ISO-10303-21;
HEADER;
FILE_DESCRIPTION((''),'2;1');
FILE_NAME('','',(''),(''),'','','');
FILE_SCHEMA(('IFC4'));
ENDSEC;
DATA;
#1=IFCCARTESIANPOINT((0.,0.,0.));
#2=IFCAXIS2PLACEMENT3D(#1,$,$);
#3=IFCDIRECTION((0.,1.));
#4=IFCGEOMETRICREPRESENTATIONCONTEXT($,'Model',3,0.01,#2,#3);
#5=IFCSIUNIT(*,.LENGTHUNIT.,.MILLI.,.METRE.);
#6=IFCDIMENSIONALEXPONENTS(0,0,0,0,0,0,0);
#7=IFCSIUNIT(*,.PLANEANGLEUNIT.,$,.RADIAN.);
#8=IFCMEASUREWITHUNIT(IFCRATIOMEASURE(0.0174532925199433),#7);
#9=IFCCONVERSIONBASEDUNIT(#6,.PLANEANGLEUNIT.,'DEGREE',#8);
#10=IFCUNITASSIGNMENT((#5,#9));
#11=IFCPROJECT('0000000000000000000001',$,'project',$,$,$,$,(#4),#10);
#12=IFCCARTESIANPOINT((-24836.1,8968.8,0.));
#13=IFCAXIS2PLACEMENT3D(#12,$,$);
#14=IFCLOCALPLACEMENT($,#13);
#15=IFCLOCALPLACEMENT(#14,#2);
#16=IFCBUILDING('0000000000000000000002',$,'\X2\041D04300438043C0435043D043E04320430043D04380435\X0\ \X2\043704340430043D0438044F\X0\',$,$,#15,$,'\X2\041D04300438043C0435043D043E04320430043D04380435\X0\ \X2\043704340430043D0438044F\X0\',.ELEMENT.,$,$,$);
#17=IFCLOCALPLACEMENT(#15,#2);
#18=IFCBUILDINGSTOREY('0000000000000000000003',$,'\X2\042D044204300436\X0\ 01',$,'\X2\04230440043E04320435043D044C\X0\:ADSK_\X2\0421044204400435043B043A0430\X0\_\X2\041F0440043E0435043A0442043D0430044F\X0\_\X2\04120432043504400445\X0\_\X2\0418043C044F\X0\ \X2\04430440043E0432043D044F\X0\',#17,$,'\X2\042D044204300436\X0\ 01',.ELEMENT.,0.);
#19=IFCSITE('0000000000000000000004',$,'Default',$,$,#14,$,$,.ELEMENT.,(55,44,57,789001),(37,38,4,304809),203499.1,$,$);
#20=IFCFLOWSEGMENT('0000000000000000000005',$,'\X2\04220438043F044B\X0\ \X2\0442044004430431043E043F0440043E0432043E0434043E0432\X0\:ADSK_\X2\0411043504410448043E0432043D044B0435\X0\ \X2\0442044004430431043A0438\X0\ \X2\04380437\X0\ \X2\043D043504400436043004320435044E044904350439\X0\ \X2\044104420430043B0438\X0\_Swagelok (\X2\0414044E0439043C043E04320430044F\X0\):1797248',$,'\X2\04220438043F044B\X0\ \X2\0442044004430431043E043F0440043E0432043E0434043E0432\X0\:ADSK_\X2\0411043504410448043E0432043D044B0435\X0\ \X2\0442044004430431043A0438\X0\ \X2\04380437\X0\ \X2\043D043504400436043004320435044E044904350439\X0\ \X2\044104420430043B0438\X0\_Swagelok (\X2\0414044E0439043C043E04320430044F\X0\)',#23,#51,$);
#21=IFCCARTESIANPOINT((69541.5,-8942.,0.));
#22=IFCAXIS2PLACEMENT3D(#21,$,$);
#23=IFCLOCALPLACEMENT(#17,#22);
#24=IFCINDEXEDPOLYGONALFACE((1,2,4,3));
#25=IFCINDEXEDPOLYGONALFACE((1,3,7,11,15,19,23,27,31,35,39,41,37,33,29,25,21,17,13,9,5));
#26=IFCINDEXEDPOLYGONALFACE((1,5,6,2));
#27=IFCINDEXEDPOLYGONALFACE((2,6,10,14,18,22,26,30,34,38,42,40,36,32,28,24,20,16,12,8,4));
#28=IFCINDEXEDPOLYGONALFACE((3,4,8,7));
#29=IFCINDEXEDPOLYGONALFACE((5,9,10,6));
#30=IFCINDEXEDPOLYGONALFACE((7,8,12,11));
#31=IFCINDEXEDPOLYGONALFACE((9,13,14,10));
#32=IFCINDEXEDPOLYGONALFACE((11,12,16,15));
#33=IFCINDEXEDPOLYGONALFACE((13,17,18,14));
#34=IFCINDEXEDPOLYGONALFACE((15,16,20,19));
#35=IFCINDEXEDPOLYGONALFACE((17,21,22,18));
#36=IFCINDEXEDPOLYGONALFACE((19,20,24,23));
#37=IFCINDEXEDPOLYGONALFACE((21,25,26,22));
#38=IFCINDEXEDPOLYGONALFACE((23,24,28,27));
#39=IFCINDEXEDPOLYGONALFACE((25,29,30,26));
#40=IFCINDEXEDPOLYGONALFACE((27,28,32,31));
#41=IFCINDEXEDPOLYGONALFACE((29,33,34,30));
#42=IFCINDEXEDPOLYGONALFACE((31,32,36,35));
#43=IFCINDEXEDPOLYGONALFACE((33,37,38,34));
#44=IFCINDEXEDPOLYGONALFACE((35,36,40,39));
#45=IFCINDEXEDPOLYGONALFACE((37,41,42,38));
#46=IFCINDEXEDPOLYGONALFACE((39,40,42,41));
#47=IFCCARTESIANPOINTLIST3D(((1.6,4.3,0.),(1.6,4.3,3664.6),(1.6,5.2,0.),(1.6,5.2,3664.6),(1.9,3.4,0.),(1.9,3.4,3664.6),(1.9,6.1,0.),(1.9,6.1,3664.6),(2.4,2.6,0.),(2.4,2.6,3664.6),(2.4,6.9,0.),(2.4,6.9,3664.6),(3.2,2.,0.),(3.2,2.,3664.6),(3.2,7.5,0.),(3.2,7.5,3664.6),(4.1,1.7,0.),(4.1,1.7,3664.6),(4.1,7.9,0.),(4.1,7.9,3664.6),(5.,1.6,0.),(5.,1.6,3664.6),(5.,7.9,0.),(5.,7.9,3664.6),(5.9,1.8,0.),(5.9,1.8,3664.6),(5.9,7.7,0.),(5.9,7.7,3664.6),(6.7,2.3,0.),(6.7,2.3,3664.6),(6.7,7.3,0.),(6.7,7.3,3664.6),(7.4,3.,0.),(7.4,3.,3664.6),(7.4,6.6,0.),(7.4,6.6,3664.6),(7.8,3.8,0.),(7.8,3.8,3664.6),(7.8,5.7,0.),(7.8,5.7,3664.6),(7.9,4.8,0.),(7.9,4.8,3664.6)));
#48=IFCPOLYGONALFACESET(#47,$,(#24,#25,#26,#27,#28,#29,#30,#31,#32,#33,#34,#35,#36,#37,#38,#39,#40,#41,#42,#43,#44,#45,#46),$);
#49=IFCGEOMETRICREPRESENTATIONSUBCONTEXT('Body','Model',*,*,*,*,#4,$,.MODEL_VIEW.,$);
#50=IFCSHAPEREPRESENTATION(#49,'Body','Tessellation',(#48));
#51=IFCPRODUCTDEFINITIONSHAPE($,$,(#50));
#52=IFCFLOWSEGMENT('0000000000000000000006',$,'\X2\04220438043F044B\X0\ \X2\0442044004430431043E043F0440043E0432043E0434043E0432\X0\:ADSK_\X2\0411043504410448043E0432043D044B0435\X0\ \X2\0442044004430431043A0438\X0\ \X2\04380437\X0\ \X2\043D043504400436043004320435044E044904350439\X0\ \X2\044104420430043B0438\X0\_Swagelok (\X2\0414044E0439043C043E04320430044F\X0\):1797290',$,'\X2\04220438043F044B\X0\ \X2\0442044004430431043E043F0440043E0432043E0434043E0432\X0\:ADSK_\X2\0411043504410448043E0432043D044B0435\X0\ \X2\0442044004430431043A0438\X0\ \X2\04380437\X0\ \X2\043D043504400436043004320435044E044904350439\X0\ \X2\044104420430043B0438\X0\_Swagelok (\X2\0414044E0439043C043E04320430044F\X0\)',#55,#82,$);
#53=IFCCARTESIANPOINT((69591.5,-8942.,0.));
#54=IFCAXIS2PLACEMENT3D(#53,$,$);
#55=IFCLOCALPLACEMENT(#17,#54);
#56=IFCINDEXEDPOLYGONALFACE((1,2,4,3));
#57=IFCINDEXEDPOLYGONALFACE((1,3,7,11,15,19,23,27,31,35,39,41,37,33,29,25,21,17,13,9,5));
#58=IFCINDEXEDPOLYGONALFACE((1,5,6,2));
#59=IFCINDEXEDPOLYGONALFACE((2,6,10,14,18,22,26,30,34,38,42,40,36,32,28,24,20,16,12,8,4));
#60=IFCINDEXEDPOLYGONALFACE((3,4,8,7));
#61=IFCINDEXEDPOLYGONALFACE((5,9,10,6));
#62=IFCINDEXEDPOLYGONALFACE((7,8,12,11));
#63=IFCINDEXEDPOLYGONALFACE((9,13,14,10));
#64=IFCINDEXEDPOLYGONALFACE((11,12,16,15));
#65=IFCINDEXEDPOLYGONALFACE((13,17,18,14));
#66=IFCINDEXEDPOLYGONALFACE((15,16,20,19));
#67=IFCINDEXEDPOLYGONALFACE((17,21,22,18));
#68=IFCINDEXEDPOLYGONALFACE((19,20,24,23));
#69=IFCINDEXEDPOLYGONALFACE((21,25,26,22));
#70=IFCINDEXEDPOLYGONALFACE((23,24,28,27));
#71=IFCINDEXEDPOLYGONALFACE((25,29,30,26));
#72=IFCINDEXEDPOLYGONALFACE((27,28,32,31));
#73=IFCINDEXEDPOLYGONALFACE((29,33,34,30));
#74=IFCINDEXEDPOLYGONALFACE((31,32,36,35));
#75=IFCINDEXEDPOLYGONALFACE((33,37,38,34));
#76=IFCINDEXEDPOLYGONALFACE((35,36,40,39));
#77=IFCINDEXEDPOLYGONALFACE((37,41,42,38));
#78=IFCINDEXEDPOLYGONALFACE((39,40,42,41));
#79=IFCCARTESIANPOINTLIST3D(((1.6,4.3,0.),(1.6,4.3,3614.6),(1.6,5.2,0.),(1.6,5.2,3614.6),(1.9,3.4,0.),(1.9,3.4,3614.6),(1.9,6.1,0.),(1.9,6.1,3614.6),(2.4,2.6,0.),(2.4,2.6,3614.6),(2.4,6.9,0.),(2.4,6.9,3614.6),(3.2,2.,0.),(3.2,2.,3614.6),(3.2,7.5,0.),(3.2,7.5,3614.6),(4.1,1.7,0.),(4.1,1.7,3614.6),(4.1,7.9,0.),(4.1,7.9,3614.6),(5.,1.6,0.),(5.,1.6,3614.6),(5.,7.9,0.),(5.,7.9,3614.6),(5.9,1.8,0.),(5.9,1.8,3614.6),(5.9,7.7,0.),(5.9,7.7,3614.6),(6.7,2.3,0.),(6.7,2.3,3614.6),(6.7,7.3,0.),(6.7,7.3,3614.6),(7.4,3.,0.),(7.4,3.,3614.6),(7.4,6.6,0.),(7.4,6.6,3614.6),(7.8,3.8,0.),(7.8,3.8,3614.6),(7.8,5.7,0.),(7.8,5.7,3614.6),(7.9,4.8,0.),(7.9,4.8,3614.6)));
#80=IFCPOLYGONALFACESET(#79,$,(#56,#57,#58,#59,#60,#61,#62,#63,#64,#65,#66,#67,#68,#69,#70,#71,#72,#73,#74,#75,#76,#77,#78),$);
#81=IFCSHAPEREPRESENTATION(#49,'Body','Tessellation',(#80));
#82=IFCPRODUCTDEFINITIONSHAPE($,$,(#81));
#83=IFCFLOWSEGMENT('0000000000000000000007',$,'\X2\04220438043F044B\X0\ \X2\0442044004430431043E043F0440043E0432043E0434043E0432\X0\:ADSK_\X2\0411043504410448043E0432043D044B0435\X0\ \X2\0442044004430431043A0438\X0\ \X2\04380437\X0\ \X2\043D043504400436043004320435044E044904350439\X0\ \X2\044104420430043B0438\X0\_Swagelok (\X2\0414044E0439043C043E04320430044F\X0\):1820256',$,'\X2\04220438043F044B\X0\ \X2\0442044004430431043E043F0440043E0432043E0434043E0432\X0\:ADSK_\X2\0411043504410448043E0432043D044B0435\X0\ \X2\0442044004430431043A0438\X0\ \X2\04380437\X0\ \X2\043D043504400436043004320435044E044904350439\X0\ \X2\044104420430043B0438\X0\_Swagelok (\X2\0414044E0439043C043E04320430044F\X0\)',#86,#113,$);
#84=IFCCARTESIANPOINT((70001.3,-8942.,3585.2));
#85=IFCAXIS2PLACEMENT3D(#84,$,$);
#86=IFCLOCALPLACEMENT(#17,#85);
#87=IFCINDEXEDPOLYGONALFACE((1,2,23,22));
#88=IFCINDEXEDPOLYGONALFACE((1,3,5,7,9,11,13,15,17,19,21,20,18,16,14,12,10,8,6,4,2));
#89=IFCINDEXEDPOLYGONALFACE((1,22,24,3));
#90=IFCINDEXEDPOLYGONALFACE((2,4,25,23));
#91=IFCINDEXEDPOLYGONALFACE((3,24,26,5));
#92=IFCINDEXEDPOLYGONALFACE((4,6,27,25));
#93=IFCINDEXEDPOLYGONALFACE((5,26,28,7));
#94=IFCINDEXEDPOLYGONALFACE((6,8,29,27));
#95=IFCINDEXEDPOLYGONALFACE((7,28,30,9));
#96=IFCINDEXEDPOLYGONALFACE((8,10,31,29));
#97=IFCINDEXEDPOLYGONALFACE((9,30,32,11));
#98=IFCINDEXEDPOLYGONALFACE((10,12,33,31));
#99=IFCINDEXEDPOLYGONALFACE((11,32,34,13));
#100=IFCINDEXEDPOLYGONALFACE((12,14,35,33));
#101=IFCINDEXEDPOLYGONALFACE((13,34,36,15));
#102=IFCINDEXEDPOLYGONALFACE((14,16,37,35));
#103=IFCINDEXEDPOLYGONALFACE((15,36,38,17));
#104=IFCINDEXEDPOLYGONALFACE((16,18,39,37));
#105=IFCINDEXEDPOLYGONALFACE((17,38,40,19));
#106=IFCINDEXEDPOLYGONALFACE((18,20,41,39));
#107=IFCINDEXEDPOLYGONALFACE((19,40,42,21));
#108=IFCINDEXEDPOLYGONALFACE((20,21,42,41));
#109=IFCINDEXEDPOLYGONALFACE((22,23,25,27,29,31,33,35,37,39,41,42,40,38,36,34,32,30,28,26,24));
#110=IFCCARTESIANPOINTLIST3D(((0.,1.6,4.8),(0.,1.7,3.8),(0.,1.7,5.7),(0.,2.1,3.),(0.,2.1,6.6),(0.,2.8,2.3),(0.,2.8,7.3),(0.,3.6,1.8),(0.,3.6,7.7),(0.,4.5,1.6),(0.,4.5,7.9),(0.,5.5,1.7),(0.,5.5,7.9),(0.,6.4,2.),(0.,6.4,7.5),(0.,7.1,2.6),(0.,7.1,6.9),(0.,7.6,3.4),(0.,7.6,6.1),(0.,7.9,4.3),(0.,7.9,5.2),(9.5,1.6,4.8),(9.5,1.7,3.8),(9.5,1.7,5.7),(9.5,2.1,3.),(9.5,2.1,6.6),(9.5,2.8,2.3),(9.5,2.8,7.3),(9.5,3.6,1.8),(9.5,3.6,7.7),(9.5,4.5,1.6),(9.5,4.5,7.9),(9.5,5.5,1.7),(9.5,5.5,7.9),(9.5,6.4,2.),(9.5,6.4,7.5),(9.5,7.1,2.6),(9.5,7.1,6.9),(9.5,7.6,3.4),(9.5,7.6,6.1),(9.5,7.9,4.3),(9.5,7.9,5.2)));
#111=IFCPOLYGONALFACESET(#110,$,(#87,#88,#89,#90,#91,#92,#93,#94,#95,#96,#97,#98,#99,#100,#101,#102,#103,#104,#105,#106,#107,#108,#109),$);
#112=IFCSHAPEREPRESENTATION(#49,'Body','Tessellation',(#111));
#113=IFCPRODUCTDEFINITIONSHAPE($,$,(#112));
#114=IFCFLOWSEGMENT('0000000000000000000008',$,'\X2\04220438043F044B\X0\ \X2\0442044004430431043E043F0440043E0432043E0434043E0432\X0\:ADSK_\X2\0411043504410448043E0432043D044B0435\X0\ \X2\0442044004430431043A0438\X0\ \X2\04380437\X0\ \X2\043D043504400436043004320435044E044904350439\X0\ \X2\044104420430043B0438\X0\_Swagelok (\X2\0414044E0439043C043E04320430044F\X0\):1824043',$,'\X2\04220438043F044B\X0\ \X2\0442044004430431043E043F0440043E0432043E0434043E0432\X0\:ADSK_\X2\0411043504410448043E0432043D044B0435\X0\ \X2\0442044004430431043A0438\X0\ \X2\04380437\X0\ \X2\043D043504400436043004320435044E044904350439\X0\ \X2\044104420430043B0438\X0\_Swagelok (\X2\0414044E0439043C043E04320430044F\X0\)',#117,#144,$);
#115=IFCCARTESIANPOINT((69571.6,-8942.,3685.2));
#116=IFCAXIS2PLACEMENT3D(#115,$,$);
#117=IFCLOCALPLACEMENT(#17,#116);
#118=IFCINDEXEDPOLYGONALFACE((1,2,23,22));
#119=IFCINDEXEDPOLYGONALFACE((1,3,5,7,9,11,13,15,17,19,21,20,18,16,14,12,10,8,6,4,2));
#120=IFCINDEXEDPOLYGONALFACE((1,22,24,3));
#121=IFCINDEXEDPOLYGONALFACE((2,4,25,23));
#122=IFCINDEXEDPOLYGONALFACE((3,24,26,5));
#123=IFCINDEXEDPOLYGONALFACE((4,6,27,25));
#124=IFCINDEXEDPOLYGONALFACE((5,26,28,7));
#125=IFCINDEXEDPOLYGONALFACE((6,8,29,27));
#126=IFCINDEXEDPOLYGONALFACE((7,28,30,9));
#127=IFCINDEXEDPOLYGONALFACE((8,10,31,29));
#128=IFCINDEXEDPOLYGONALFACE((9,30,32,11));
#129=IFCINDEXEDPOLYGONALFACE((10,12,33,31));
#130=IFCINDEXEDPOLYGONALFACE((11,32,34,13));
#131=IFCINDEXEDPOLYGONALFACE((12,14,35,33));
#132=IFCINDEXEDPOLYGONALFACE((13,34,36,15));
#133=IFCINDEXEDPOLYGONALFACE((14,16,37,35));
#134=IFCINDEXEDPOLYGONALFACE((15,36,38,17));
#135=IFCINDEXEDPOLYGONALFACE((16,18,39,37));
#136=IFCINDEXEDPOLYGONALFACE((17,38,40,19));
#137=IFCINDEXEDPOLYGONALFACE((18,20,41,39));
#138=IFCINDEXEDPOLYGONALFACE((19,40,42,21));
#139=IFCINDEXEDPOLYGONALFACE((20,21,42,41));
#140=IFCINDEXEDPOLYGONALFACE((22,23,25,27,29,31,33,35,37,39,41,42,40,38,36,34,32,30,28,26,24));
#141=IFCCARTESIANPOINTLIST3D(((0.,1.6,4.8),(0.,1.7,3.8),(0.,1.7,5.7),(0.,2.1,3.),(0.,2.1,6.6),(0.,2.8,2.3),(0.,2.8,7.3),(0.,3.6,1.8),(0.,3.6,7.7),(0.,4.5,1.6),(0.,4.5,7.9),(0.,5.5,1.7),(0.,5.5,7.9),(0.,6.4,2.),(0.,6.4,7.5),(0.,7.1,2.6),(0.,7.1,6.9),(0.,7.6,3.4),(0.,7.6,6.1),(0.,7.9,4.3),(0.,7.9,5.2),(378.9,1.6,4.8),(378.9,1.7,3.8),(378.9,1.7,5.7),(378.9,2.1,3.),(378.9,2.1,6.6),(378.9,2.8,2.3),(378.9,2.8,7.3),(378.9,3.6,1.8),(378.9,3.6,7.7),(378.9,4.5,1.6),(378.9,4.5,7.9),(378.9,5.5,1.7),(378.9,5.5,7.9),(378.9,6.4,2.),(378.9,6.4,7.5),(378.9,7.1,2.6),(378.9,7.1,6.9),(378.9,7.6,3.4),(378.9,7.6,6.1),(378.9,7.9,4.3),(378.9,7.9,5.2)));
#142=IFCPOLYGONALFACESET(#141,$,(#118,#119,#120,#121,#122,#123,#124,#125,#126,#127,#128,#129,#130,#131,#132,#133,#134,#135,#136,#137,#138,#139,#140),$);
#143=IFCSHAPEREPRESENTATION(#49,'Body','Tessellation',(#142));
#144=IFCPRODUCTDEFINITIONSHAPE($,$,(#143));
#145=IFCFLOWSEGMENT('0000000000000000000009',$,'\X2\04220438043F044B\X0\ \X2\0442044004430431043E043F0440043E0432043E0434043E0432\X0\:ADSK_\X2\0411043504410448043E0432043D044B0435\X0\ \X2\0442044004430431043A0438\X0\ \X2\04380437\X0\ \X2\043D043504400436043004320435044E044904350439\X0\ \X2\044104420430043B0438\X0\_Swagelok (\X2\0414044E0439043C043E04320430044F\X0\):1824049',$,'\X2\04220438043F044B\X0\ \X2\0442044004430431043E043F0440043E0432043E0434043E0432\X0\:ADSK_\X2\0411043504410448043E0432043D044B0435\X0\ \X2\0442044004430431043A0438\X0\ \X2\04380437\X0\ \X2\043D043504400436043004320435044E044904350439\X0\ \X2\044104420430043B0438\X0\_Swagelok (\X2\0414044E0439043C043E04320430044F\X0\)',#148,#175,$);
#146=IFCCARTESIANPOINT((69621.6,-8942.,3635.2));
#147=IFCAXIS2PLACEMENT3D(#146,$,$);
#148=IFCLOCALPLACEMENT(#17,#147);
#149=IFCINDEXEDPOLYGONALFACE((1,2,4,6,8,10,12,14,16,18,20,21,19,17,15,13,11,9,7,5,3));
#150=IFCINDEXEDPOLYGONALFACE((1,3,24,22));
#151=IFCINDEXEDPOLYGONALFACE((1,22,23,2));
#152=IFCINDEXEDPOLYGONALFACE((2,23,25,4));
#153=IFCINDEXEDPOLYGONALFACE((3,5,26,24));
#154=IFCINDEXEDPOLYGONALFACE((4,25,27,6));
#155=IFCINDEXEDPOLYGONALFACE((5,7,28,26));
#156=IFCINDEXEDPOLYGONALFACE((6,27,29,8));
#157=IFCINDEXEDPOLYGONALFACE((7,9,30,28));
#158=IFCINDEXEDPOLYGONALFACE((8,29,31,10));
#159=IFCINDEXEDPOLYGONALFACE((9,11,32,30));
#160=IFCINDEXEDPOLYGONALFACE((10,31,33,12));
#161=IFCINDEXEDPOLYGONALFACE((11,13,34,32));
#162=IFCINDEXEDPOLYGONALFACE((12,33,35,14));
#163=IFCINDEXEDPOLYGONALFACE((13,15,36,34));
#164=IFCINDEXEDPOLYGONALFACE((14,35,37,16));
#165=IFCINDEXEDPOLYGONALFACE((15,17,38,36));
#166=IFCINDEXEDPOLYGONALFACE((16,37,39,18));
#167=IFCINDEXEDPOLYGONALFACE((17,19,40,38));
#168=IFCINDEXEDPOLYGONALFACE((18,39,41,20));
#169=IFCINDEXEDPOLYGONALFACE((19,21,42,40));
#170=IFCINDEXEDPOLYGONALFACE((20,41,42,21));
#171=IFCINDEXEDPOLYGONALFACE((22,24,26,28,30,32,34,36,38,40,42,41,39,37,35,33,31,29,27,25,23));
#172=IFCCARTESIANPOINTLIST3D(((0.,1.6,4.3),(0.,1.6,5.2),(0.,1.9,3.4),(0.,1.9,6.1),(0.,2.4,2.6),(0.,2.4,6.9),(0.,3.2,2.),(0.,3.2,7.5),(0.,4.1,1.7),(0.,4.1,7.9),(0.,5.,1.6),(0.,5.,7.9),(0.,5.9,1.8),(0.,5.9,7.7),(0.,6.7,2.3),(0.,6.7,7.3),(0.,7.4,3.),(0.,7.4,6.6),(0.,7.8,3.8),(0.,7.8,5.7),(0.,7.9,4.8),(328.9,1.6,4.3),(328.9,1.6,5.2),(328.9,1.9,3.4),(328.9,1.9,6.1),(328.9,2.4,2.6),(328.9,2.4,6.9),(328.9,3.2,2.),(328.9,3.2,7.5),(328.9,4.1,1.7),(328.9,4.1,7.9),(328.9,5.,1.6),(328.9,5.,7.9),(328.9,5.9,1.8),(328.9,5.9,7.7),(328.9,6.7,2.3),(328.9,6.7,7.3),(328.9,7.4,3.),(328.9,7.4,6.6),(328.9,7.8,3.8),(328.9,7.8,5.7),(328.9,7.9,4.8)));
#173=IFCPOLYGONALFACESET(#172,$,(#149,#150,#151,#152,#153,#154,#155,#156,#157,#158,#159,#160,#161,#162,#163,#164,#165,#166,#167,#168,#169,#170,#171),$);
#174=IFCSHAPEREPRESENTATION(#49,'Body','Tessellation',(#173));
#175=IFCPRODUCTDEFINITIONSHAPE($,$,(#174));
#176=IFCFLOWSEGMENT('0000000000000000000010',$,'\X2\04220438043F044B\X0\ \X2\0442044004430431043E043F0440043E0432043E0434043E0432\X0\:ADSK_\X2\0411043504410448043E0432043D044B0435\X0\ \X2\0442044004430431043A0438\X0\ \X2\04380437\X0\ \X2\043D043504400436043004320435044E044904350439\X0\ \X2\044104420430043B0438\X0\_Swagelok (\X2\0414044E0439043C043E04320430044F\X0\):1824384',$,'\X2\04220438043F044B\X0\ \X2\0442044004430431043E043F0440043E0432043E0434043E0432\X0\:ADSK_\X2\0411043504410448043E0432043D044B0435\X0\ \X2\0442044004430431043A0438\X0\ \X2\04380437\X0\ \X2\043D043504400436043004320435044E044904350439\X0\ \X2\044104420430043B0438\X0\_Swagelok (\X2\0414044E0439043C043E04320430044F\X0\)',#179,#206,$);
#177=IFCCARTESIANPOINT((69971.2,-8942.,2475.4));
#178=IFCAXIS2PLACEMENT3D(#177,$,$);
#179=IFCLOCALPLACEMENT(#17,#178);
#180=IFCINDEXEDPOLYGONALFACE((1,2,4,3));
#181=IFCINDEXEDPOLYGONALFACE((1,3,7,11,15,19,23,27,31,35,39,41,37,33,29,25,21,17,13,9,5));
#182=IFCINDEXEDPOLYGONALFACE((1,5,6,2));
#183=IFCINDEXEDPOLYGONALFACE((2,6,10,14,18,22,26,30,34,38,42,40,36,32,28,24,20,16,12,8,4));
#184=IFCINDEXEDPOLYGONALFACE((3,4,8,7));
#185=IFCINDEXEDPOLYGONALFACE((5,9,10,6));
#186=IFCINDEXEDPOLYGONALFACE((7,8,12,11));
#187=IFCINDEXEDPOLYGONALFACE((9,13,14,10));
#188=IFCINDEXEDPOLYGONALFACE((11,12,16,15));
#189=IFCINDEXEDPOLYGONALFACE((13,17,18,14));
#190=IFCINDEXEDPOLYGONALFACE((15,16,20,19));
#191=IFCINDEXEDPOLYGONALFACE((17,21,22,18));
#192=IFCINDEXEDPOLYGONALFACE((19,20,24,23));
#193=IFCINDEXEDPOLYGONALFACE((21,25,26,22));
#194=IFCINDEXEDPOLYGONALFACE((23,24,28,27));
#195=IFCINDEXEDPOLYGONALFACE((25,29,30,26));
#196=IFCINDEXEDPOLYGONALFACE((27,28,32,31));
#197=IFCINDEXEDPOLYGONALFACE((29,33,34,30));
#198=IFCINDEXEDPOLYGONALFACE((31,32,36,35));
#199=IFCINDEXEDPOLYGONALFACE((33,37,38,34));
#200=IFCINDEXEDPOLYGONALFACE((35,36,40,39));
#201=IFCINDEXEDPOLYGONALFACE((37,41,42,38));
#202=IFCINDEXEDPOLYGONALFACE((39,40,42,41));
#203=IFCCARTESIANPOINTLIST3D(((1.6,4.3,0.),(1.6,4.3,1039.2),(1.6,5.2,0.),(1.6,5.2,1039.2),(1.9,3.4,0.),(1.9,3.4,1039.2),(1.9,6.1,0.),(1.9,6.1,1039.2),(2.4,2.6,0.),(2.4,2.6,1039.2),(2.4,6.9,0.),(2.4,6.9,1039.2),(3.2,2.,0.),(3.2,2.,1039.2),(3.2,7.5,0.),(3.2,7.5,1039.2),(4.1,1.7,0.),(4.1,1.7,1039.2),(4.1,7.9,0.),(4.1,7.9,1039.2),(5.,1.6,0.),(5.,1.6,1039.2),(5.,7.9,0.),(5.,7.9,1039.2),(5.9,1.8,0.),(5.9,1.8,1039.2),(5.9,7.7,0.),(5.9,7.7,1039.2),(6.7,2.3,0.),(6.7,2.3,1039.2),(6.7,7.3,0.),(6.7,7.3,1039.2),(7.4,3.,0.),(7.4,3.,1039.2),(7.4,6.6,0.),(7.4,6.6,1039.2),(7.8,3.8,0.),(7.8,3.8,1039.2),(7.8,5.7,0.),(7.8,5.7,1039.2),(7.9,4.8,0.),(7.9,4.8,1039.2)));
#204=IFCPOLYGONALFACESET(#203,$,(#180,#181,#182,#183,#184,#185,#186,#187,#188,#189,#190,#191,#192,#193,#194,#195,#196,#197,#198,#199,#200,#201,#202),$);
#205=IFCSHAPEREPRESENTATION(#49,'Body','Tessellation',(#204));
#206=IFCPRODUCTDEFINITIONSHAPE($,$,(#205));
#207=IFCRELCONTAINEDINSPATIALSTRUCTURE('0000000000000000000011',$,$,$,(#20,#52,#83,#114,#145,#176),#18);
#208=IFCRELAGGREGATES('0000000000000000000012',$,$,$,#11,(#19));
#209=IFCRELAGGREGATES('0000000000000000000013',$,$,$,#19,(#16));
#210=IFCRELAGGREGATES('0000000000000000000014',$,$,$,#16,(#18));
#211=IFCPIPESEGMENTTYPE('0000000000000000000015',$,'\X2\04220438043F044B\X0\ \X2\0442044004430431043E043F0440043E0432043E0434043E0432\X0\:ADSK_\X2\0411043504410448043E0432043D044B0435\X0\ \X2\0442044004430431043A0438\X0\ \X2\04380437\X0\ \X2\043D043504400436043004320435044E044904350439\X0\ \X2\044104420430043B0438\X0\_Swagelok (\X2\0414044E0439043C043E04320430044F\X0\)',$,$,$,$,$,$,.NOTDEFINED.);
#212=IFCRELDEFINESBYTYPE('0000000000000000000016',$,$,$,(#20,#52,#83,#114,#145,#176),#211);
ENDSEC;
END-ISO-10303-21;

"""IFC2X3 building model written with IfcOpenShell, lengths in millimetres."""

from ifc_helpers import new_model, entity, si_unit, converted_unit, direction, frame, origin, origin_2d_with_axis, place, context, subcontext, project, spatial, circle, extrude, type_object, element, save


model = new_model("IFC2X3")

# Units and contexts
model_context = context("Model", 3, precision=0.01, world=origin(), true_north=direction((0.0, 1.0)))
body_context = subcontext(model_context, "Body", "Model", "MODEL_VIEW")
ifc_project = project(units=[si_unit("LENGTHUNIT", "METRE", prefix="MILLI"), converted_unit("PLANEANGLEUNIT", "DEGREE", entity("IfcRatioMeasure", 0.0174532925199433), si_unit("PLANEANGLEUNIT", "RADIAN"), dimensions=[0, 0, 0, 0, 0, 0, 0])], contexts=[model_context])

# Site, building, storey
site_placement = place(None, frame((-24836.1, 8968.8, 0.0)))
site = spatial("IfcSite", under=ifc_project, at=site_placement, Name="Default", CompositionType="ELEMENT", RefLatitude=(55, 44, 57, 789001), RefLongitude=(37, 38, 4, 304809), RefElevation=203499.1)
building_placement = place(site_placement, origin())
building = spatial("IfcBuilding", under=site, at=building_placement, Name="Наименование здания", LongName="Наименование здания", CompositionType="ELEMENT")
storey_placement = place(building_placement, origin())
storey = spatial("IfcBuildingStorey", under=building, at=storey_placement, Name="Этаж 01", ObjectType="Уровень:ADSK_Стрелка_Проектная_Вверх_Имя уровня", LongName="Этаж 01", CompositionType="ELEMENT", Elevation=0.0)

# Flow segments
pipe_segment_type_1 = type_object("IfcPipeSegmentType", Name="Типы трубопроводов:ADSK_Бесшовные трубки из нержавеющей стали_Swagelok (Дюймовая)", PredefinedType="NOTDEFINED")
flow_segment_1_placement = place(storey_placement, frame((69541.5, -8942.0, 0.0)))
element("IfcFlowSegment", 1, at=flow_segment_1_placement, inside=storey, type_object=pipe_segment_type_1, Name="Типы трубопроводов:ADSK_Бесшовные трубки из нержавеющей стали_Swagelok (Дюймовая):1797248", ObjectType="Типы трубопроводов:ADSK_Бесшовные трубки из нержавеющей стали_Swagelok (Дюймовая)", context=body_context, shape_type="SweptSolid", body=[
    extrude(circle(Radius=3.2, at=origin_2d_with_axis()), frame((4.8, 4.8, 0.0)), (0.0, 0.0, 1.0), 3664.6),
])
flow_segment_2_placement = place(storey_placement, frame((69591.5, -8942.0, 0.0)))
element("IfcFlowSegment", 2, at=flow_segment_2_placement, inside=storey, type_object=pipe_segment_type_1, Name="Типы трубопроводов:ADSK_Бесшовные трубки из нержавеющей стали_Swagelok (Дюймовая):1797290", ObjectType="Типы трубопроводов:ADSK_Бесшовные трубки из нержавеющей стали_Swagelok (Дюймовая)", context=body_context, shape_type="SweptSolid", body=[
    extrude(circle(Radius=3.2, at=origin_2d_with_axis()), frame((4.8, 4.8, 0.0)), (0.0, 0.0, 1.0), 3614.6),
])
flow_segment_3_placement = place(storey_placement, frame((70001.3, -8942.0, 3585.2)))
element("IfcFlowSegment", 3, at=flow_segment_3_placement, inside=storey, type_object=pipe_segment_type_1, Name="Типы трубопроводов:ADSK_Бесшовные трубки из нержавеющей стали_Swagelok (Дюймовая):1820256", ObjectType="Типы трубопроводов:ADSK_Бесшовные трубки из нержавеющей стали_Swagelok (Дюймовая)", context=body_context, shape_type="SweptSolid", body=[
    extrude(circle(Radius=3.2, at=origin_2d_with_axis()), frame((0.0, 4.8, 4.8), z_axis=(1.0, 0.0, 0.0), x_axis=(0.0, -1.0, 0.0)), (0.0, 0.0, 1.0), 9.5),
])
flow_segment_4_placement = place(storey_placement, frame((69571.6, -8942.0, 3685.2)))
element("IfcFlowSegment", 4, at=flow_segment_4_placement, inside=storey, type_object=pipe_segment_type_1, Name="Типы трубопроводов:ADSK_Бесшовные трубки из нержавеющей стали_Swagelok (Дюймовая):1824043", ObjectType="Типы трубопроводов:ADSK_Бесшовные трубки из нержавеющей стали_Swagelok (Дюймовая)", context=body_context, shape_type="SweptSolid", body=[
    extrude(circle(Radius=3.2, at=origin_2d_with_axis()), frame((0.0, 4.8, 4.8), z_axis=(1.0, 0.0, 0.0), x_axis=(0.0, -1.0, 0.0)), (0.0, 0.0, 1.0), 378.9),
])
flow_segment_5_placement = place(storey_placement, frame((69621.6, -8942.0, 3635.2)))
element("IfcFlowSegment", 5, at=flow_segment_5_placement, inside=storey, type_object=pipe_segment_type_1, Name="Типы трубопроводов:ADSK_Бесшовные трубки из нержавеющей стали_Swagelok (Дюймовая):1824049", ObjectType="Типы трубопроводов:ADSK_Бесшовные трубки из нержавеющей стали_Swagelok (Дюймовая)", context=body_context, shape_type="SweptSolid", body=[
    extrude(circle(Radius=3.2, at=origin_2d_with_axis()), frame((0.0, 4.8, 4.8), z_axis=(1.0, 0.0, 0.0), x_axis=(0.0, 1.0, 0.0)), (0.0, 0.0, 1.0), 328.9),
])
flow_segment_6_placement = place(storey_placement, frame((69971.2, -8942.0, 2475.4)))
element("IfcFlowSegment", 6, at=flow_segment_6_placement, inside=storey, type_object=pipe_segment_type_1, Name="Типы трубопроводов:ADSK_Бесшовные трубки из нержавеющей стали_Swagelok (Дюймовая):1824384", ObjectType="Типы трубопроводов:ADSK_Бесшовные трубки из нержавеющей стали_Swagelok (Дюймовая)", context=body_context, shape_type="SweptSolid", body=[
    extrude(circle(Radius=3.2, at=origin_2d_with_axis()), frame((4.8, 4.8, 0.0)), (0.0, 0.0, 1.0), 1039.2),
])

save(model, "model.ifc")
